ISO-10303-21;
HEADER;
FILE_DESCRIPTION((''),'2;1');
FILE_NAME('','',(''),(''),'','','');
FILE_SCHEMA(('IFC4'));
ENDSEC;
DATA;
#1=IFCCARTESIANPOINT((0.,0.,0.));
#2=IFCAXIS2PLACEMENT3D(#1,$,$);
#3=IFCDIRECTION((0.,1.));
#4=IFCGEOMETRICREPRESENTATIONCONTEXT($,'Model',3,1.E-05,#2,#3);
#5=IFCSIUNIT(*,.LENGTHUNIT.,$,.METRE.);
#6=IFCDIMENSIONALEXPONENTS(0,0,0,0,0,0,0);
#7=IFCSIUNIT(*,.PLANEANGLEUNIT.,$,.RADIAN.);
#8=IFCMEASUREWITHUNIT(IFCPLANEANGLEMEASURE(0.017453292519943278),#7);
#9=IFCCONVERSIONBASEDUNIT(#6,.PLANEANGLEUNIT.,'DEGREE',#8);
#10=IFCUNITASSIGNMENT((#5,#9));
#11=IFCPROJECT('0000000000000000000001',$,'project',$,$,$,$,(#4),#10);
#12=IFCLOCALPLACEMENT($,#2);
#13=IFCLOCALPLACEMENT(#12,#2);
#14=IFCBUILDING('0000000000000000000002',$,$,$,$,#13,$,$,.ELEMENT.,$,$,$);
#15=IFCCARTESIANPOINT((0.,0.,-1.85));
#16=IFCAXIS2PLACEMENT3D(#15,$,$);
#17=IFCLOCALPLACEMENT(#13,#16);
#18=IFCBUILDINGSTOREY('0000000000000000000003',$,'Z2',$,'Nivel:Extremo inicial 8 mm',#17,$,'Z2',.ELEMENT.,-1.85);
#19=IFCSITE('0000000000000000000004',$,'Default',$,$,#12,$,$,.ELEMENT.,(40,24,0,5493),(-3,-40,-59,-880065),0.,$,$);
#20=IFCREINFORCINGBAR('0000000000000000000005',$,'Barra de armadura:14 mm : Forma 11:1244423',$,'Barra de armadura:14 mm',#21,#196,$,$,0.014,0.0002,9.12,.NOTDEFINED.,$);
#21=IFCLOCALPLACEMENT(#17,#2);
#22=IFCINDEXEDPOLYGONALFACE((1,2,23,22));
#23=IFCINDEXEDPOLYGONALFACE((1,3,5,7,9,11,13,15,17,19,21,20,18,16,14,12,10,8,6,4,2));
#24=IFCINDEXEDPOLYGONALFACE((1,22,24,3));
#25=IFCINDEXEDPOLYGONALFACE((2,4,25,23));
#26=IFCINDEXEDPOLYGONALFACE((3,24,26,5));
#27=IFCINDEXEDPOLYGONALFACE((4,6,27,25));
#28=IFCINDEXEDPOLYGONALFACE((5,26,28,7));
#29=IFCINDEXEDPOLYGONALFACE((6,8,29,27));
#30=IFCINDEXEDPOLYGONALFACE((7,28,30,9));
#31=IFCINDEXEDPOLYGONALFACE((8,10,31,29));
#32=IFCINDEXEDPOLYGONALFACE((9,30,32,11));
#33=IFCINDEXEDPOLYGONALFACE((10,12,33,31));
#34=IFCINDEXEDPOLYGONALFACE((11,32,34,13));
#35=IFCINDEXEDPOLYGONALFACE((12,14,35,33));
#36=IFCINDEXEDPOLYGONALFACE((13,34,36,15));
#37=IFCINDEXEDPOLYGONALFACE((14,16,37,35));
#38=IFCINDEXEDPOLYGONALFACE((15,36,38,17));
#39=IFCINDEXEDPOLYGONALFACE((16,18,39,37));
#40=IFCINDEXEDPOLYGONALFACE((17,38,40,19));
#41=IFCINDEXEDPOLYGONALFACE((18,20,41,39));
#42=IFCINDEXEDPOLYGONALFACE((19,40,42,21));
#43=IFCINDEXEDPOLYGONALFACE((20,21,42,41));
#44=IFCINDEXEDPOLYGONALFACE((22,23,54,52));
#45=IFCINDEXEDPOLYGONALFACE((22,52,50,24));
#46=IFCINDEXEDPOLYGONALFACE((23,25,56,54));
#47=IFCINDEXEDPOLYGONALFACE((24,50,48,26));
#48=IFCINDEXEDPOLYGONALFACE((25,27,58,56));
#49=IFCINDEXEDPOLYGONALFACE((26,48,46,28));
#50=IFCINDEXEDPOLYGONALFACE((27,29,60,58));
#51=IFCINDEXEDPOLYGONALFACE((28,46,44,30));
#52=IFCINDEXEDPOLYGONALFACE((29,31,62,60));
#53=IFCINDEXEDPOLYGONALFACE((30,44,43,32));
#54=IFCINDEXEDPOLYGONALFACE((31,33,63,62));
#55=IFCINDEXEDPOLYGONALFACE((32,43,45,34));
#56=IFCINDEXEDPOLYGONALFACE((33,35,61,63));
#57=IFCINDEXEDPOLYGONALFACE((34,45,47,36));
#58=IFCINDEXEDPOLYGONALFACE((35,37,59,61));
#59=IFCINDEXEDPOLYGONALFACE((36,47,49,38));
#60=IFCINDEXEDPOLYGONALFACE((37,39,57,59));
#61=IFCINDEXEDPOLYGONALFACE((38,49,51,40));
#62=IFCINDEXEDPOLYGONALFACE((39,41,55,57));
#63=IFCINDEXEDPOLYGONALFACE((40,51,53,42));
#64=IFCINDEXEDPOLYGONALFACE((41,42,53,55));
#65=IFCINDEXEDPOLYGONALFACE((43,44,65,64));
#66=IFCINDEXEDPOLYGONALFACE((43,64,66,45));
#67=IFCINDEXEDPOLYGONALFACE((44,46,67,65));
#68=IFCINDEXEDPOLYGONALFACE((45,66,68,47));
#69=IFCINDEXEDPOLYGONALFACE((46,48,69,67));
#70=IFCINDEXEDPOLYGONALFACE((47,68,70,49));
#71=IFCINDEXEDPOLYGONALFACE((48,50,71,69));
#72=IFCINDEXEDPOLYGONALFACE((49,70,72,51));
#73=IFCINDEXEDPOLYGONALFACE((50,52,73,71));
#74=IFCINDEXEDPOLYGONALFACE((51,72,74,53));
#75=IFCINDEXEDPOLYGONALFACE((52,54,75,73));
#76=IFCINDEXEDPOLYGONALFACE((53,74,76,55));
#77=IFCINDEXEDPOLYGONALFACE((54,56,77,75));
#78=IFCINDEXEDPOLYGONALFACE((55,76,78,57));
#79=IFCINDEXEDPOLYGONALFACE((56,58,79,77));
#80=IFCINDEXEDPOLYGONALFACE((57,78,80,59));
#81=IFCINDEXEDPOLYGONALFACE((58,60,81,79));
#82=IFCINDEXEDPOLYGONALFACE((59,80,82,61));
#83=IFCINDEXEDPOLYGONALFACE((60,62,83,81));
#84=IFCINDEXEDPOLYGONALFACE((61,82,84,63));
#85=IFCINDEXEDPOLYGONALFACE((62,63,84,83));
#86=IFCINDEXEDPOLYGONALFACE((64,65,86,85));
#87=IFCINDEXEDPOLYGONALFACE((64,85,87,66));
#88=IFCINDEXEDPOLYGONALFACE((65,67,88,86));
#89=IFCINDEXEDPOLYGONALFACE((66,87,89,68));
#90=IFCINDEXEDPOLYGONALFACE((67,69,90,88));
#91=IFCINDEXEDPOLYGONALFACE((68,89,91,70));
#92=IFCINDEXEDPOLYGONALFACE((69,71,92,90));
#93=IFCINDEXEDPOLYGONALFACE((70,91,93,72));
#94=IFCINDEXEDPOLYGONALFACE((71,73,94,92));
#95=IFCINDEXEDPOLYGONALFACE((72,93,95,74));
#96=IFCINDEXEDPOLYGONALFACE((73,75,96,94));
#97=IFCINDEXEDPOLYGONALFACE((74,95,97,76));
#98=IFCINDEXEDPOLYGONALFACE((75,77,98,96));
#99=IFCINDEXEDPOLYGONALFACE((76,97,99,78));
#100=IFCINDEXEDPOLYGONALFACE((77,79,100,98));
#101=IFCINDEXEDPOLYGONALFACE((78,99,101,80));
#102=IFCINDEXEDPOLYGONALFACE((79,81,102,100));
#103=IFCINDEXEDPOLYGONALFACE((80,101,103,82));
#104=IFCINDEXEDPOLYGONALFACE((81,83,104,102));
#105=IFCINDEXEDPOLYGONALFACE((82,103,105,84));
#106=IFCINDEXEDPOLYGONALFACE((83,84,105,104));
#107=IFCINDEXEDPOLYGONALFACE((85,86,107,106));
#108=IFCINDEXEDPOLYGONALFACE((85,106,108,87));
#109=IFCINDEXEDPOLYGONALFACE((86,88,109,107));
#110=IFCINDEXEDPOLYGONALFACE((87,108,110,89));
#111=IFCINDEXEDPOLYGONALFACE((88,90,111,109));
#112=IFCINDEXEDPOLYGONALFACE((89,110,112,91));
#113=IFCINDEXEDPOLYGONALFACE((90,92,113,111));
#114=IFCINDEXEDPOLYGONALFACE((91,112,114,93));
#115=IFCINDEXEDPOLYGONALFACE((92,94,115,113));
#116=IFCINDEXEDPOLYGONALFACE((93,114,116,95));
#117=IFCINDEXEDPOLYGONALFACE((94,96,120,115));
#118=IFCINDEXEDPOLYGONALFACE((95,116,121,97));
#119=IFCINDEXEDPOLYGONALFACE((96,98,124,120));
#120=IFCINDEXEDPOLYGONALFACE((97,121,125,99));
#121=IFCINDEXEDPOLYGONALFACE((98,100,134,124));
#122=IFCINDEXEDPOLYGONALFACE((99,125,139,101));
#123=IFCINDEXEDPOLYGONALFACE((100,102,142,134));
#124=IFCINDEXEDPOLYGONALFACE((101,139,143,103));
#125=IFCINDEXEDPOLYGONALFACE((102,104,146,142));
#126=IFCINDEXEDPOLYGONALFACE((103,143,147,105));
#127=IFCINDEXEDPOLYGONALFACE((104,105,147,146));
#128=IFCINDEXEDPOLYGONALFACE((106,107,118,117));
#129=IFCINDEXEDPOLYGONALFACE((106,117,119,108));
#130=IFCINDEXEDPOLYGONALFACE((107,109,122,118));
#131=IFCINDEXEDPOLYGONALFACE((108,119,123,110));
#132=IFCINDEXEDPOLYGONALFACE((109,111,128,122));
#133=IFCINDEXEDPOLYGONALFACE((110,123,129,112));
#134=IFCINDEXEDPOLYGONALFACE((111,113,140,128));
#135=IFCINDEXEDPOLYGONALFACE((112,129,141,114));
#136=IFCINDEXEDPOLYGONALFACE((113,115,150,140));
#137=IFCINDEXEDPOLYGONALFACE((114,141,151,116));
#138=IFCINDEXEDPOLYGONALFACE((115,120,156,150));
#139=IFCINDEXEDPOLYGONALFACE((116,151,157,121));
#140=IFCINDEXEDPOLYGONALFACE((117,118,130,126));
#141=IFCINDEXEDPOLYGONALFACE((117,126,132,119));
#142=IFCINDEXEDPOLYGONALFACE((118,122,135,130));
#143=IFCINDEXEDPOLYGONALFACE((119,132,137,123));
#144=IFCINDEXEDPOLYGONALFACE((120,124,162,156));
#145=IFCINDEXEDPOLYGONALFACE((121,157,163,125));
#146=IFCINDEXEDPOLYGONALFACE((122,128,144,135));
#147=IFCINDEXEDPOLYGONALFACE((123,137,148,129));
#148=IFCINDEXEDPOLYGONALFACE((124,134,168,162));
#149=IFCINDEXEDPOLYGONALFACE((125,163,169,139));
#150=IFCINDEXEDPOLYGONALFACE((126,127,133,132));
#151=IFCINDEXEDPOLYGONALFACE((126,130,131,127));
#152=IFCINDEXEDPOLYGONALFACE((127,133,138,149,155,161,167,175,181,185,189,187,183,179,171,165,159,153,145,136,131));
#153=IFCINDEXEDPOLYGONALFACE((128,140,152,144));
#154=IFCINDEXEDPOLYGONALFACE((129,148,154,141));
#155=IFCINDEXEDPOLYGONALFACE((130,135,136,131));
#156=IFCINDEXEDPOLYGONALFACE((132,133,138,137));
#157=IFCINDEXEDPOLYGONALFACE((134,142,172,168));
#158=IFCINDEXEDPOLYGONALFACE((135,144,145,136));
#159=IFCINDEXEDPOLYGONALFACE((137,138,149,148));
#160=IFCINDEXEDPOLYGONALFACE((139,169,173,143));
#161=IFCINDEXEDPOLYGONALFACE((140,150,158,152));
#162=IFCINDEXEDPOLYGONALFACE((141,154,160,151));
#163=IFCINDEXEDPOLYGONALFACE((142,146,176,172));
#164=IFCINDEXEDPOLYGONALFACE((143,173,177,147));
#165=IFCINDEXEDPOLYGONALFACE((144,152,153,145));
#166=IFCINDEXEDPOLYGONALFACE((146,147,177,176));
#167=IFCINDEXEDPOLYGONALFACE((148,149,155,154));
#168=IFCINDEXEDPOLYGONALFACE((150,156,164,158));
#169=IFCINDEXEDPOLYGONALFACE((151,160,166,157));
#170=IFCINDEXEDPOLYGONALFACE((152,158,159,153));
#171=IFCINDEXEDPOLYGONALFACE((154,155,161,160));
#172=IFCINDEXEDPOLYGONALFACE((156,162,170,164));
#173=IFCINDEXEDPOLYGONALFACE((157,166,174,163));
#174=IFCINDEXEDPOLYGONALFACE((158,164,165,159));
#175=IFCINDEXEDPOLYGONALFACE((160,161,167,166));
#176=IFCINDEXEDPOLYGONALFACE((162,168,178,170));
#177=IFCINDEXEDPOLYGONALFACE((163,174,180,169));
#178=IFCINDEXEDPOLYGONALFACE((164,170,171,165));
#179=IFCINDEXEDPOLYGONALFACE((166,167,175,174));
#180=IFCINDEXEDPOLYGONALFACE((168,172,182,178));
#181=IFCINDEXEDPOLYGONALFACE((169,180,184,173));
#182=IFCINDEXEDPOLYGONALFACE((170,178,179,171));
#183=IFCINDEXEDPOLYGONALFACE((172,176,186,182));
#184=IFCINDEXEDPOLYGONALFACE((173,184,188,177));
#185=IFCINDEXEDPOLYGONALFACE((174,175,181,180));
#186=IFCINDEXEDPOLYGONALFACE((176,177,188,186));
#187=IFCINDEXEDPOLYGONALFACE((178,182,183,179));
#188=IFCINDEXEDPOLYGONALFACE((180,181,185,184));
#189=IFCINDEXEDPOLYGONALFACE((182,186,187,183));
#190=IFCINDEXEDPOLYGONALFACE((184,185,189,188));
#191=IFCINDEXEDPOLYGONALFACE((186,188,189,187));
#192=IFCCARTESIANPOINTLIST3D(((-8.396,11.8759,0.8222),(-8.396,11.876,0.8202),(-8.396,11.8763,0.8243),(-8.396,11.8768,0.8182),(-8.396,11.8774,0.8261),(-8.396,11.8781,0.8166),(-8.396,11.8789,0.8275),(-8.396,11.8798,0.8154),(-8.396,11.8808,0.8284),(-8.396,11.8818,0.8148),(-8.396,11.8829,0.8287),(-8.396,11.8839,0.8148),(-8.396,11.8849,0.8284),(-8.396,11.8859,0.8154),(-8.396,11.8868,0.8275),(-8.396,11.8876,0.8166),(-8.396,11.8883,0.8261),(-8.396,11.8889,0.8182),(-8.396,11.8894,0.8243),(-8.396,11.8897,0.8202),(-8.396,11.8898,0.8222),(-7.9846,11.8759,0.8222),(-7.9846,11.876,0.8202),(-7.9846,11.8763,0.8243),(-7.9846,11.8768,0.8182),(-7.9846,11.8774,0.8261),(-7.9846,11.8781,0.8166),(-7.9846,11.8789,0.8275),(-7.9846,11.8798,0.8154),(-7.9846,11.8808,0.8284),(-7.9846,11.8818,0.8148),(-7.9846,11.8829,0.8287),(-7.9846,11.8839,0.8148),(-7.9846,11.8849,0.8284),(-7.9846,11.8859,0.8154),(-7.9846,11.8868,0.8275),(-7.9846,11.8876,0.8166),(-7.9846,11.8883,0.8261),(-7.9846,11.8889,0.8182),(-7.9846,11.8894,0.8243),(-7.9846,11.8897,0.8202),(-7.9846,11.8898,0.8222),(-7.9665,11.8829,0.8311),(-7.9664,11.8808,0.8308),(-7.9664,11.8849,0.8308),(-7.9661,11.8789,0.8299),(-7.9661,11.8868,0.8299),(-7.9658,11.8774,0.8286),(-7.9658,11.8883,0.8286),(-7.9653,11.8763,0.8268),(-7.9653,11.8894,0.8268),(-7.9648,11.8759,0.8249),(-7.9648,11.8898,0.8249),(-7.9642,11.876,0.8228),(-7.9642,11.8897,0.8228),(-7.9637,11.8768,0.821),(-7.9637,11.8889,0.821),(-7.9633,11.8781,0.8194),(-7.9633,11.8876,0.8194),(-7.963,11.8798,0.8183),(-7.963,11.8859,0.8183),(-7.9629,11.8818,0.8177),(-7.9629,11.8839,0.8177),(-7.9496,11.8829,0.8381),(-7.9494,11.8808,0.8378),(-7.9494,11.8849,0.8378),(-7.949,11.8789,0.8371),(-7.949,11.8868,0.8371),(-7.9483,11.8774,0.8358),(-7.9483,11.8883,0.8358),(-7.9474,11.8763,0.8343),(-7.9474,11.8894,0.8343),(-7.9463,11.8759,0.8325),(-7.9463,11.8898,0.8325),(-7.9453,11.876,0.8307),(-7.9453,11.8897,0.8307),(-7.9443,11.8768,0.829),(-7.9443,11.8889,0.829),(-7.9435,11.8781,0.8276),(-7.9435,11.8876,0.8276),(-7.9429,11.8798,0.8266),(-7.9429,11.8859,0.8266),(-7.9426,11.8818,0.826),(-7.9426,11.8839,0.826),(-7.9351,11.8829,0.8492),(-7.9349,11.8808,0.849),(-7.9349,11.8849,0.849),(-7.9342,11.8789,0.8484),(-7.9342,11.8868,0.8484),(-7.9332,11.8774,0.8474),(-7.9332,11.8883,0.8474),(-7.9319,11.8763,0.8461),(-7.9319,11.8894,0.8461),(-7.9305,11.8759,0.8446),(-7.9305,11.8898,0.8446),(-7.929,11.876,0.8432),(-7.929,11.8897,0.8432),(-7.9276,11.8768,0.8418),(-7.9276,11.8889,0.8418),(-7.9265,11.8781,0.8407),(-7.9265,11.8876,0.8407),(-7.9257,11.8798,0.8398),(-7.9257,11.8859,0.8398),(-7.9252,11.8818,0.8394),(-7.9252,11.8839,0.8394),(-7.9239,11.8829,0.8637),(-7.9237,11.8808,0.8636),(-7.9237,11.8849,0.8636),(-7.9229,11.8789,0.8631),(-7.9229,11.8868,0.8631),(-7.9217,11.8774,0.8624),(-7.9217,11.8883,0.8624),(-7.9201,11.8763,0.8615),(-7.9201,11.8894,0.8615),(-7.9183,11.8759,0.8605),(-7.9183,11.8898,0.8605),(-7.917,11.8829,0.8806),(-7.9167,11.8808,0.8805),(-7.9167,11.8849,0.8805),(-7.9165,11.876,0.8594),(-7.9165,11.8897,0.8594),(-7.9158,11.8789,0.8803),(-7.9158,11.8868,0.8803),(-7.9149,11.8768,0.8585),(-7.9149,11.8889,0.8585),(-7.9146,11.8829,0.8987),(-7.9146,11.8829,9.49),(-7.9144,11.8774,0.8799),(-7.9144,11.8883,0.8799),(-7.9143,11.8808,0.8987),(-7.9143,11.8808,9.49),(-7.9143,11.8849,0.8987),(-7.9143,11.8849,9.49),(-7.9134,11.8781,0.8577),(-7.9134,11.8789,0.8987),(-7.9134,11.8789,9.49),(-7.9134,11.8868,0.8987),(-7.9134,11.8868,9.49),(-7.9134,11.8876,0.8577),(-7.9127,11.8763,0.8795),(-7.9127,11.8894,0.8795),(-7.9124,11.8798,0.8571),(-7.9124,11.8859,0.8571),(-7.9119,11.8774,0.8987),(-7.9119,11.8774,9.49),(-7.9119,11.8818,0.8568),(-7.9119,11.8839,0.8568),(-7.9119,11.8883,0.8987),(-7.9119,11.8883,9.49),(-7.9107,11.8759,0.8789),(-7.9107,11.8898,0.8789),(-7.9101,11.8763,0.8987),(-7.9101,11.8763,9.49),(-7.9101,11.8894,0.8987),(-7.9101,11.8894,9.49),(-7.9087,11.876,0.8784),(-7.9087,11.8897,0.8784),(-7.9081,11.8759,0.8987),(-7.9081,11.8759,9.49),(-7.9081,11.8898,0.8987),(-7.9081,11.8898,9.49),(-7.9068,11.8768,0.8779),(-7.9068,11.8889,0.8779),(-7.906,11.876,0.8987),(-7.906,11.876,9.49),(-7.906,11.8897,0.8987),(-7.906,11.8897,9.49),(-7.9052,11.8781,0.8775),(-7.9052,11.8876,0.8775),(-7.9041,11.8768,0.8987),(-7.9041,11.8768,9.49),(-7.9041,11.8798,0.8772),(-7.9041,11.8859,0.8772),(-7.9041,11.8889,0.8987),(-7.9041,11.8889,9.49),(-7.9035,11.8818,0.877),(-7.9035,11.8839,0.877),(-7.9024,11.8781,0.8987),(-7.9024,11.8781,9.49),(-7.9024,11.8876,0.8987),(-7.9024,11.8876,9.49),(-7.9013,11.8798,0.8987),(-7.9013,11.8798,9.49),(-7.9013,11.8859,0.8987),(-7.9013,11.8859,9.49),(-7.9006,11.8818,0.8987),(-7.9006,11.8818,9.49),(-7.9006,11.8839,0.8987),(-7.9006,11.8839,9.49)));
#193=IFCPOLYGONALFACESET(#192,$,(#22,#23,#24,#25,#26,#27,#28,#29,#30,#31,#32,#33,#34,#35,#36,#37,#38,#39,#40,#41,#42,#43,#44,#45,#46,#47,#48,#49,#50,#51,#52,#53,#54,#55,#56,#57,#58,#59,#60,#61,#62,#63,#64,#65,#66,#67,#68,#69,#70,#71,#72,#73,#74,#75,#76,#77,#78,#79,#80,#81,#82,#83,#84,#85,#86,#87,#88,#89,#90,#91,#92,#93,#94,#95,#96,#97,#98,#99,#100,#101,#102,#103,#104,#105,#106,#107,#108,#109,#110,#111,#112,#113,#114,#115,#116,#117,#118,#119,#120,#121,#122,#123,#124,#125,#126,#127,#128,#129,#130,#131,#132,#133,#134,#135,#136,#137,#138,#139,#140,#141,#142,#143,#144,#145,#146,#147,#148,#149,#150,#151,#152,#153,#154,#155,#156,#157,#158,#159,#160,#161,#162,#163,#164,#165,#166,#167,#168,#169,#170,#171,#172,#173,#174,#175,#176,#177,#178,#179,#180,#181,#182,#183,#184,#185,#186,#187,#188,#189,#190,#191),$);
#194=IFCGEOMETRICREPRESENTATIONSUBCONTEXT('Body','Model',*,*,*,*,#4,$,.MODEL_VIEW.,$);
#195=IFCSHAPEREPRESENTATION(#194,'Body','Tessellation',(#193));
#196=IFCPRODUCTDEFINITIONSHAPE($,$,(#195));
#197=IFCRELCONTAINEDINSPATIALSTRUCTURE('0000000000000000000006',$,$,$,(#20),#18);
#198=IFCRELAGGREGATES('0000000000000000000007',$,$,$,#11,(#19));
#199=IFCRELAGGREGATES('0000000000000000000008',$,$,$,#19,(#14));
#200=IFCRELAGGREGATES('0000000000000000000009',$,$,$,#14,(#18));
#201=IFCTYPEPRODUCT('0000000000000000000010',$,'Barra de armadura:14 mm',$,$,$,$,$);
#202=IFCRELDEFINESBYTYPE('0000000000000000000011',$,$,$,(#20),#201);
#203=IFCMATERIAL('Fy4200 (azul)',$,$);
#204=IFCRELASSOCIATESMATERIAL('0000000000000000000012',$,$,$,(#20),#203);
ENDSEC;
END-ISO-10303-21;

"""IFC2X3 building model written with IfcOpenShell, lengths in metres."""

from ifc_helpers import new_model, entity, si_unit, converted_unit, direction, frame, origin, place, context, subcontext, project, spatial, material, type_object, element, save


model = new_model("IFC2X3")

# Units and contexts
model_context = context("Model", 3, precision=1e-05, world=origin(), true_north=direction((0.0, 1.0)))
body_context = subcontext(model_context, "Body", "Model", "MODEL_VIEW")
ifc_project = project(units=[si_unit("LENGTHUNIT", "METRE"), converted_unit("PLANEANGLEUNIT", "DEGREE", entity("IfcPlaneAngleMeasure", 0.017453292519943278), si_unit("PLANEANGLEUNIT", "RADIAN"), dimensions=[0, 0, 0, 0, 0, 0, 0])], contexts=[model_context])

# Site, building, storey
site_placement = place(None, origin())
site = spatial("IfcSite", under=ifc_project, at=site_placement, Name="Default", CompositionType="ELEMENT", RefLatitude=(40, 24, 0, 5493), RefLongitude=(-3, -40, -59, -880065), RefElevation=0.0)
building_placement = place(site_placement, origin())
building = spatial("IfcBuilding", under=site, at=building_placement, CompositionType="ELEMENT")
storey_placement = place(building_placement, frame((0.0, 0.0, -1.85)))
storey = spatial("IfcBuildingStorey", under=building, at=storey_placement, Name="Z2", ObjectType="Nivel:Extremo inicial 8 mm", LongName="Z2", CompositionType="ELEMENT", Elevation=-1.85)

# Reinforcing bar
ifc_material_1 = material(Name="Fy4200 (azul)")
type_product_1 = type_object("IfcTypeProduct", Name="Barra de armadura:14 mm")
reinforcing_bar_1_placement = place(storey_placement, origin())
element("IfcReinforcingBar", 1, at=reinforcing_bar_1_placement, inside=storey, type_object=type_product_1, material=ifc_material_1, Name="Barra de armadura:14 mm : Forma 11:1244423", ObjectType="Barra de armadura:14 mm", BarLength=9.12, BarRole="NOTDEFINED", CrossSectionArea=0.0002, NominalDiameter=0.014, context=body_context, shape_type="AdvancedSweptSolid", body=[
    entity("IfcSweptDiskSolid", entity("IfcCompositeCurve", [entity("IfcCompositeCurveSegment", "CONTINUOUS", True, entity("IfcPolyline", [entity("IfcCartesianPoint", [-7.9076, 11.8829, 9.49]), entity("IfcCartesianPoint", [-7.9076, 11.8829, 0.8987])])), entity("IfcCompositeCurveSegment", "CONTINUOUS", True, entity("IfcTrimmedCurve", entity("IfcCircle", entity("IfcAxis2Placement3D", entity("IfcCartesianPoint", [-7.9846, 11.8829, 0.8987]), entity("IfcDirection", [0.0, 1.0, 0.0]), entity("IfcDirection", [0.0, 0.0, -1.0])), 0.077), [entity("IfcParameterValue", 270.0)], [entity("IfcParameterValue", 360.0)], True, "PARAMETER")), entity("IfcCompositeCurveSegment", "CONTINUOUS", True, entity("IfcPolyline", [entity("IfcCartesianPoint", [-7.9846, 11.8829, 0.8217]), entity("IfcCartesianPoint", [-8.396, 11.8829, 0.8217])]))], False), 0.007, None, 0.0, 92.0),
])

save(model, "model.ifc")
